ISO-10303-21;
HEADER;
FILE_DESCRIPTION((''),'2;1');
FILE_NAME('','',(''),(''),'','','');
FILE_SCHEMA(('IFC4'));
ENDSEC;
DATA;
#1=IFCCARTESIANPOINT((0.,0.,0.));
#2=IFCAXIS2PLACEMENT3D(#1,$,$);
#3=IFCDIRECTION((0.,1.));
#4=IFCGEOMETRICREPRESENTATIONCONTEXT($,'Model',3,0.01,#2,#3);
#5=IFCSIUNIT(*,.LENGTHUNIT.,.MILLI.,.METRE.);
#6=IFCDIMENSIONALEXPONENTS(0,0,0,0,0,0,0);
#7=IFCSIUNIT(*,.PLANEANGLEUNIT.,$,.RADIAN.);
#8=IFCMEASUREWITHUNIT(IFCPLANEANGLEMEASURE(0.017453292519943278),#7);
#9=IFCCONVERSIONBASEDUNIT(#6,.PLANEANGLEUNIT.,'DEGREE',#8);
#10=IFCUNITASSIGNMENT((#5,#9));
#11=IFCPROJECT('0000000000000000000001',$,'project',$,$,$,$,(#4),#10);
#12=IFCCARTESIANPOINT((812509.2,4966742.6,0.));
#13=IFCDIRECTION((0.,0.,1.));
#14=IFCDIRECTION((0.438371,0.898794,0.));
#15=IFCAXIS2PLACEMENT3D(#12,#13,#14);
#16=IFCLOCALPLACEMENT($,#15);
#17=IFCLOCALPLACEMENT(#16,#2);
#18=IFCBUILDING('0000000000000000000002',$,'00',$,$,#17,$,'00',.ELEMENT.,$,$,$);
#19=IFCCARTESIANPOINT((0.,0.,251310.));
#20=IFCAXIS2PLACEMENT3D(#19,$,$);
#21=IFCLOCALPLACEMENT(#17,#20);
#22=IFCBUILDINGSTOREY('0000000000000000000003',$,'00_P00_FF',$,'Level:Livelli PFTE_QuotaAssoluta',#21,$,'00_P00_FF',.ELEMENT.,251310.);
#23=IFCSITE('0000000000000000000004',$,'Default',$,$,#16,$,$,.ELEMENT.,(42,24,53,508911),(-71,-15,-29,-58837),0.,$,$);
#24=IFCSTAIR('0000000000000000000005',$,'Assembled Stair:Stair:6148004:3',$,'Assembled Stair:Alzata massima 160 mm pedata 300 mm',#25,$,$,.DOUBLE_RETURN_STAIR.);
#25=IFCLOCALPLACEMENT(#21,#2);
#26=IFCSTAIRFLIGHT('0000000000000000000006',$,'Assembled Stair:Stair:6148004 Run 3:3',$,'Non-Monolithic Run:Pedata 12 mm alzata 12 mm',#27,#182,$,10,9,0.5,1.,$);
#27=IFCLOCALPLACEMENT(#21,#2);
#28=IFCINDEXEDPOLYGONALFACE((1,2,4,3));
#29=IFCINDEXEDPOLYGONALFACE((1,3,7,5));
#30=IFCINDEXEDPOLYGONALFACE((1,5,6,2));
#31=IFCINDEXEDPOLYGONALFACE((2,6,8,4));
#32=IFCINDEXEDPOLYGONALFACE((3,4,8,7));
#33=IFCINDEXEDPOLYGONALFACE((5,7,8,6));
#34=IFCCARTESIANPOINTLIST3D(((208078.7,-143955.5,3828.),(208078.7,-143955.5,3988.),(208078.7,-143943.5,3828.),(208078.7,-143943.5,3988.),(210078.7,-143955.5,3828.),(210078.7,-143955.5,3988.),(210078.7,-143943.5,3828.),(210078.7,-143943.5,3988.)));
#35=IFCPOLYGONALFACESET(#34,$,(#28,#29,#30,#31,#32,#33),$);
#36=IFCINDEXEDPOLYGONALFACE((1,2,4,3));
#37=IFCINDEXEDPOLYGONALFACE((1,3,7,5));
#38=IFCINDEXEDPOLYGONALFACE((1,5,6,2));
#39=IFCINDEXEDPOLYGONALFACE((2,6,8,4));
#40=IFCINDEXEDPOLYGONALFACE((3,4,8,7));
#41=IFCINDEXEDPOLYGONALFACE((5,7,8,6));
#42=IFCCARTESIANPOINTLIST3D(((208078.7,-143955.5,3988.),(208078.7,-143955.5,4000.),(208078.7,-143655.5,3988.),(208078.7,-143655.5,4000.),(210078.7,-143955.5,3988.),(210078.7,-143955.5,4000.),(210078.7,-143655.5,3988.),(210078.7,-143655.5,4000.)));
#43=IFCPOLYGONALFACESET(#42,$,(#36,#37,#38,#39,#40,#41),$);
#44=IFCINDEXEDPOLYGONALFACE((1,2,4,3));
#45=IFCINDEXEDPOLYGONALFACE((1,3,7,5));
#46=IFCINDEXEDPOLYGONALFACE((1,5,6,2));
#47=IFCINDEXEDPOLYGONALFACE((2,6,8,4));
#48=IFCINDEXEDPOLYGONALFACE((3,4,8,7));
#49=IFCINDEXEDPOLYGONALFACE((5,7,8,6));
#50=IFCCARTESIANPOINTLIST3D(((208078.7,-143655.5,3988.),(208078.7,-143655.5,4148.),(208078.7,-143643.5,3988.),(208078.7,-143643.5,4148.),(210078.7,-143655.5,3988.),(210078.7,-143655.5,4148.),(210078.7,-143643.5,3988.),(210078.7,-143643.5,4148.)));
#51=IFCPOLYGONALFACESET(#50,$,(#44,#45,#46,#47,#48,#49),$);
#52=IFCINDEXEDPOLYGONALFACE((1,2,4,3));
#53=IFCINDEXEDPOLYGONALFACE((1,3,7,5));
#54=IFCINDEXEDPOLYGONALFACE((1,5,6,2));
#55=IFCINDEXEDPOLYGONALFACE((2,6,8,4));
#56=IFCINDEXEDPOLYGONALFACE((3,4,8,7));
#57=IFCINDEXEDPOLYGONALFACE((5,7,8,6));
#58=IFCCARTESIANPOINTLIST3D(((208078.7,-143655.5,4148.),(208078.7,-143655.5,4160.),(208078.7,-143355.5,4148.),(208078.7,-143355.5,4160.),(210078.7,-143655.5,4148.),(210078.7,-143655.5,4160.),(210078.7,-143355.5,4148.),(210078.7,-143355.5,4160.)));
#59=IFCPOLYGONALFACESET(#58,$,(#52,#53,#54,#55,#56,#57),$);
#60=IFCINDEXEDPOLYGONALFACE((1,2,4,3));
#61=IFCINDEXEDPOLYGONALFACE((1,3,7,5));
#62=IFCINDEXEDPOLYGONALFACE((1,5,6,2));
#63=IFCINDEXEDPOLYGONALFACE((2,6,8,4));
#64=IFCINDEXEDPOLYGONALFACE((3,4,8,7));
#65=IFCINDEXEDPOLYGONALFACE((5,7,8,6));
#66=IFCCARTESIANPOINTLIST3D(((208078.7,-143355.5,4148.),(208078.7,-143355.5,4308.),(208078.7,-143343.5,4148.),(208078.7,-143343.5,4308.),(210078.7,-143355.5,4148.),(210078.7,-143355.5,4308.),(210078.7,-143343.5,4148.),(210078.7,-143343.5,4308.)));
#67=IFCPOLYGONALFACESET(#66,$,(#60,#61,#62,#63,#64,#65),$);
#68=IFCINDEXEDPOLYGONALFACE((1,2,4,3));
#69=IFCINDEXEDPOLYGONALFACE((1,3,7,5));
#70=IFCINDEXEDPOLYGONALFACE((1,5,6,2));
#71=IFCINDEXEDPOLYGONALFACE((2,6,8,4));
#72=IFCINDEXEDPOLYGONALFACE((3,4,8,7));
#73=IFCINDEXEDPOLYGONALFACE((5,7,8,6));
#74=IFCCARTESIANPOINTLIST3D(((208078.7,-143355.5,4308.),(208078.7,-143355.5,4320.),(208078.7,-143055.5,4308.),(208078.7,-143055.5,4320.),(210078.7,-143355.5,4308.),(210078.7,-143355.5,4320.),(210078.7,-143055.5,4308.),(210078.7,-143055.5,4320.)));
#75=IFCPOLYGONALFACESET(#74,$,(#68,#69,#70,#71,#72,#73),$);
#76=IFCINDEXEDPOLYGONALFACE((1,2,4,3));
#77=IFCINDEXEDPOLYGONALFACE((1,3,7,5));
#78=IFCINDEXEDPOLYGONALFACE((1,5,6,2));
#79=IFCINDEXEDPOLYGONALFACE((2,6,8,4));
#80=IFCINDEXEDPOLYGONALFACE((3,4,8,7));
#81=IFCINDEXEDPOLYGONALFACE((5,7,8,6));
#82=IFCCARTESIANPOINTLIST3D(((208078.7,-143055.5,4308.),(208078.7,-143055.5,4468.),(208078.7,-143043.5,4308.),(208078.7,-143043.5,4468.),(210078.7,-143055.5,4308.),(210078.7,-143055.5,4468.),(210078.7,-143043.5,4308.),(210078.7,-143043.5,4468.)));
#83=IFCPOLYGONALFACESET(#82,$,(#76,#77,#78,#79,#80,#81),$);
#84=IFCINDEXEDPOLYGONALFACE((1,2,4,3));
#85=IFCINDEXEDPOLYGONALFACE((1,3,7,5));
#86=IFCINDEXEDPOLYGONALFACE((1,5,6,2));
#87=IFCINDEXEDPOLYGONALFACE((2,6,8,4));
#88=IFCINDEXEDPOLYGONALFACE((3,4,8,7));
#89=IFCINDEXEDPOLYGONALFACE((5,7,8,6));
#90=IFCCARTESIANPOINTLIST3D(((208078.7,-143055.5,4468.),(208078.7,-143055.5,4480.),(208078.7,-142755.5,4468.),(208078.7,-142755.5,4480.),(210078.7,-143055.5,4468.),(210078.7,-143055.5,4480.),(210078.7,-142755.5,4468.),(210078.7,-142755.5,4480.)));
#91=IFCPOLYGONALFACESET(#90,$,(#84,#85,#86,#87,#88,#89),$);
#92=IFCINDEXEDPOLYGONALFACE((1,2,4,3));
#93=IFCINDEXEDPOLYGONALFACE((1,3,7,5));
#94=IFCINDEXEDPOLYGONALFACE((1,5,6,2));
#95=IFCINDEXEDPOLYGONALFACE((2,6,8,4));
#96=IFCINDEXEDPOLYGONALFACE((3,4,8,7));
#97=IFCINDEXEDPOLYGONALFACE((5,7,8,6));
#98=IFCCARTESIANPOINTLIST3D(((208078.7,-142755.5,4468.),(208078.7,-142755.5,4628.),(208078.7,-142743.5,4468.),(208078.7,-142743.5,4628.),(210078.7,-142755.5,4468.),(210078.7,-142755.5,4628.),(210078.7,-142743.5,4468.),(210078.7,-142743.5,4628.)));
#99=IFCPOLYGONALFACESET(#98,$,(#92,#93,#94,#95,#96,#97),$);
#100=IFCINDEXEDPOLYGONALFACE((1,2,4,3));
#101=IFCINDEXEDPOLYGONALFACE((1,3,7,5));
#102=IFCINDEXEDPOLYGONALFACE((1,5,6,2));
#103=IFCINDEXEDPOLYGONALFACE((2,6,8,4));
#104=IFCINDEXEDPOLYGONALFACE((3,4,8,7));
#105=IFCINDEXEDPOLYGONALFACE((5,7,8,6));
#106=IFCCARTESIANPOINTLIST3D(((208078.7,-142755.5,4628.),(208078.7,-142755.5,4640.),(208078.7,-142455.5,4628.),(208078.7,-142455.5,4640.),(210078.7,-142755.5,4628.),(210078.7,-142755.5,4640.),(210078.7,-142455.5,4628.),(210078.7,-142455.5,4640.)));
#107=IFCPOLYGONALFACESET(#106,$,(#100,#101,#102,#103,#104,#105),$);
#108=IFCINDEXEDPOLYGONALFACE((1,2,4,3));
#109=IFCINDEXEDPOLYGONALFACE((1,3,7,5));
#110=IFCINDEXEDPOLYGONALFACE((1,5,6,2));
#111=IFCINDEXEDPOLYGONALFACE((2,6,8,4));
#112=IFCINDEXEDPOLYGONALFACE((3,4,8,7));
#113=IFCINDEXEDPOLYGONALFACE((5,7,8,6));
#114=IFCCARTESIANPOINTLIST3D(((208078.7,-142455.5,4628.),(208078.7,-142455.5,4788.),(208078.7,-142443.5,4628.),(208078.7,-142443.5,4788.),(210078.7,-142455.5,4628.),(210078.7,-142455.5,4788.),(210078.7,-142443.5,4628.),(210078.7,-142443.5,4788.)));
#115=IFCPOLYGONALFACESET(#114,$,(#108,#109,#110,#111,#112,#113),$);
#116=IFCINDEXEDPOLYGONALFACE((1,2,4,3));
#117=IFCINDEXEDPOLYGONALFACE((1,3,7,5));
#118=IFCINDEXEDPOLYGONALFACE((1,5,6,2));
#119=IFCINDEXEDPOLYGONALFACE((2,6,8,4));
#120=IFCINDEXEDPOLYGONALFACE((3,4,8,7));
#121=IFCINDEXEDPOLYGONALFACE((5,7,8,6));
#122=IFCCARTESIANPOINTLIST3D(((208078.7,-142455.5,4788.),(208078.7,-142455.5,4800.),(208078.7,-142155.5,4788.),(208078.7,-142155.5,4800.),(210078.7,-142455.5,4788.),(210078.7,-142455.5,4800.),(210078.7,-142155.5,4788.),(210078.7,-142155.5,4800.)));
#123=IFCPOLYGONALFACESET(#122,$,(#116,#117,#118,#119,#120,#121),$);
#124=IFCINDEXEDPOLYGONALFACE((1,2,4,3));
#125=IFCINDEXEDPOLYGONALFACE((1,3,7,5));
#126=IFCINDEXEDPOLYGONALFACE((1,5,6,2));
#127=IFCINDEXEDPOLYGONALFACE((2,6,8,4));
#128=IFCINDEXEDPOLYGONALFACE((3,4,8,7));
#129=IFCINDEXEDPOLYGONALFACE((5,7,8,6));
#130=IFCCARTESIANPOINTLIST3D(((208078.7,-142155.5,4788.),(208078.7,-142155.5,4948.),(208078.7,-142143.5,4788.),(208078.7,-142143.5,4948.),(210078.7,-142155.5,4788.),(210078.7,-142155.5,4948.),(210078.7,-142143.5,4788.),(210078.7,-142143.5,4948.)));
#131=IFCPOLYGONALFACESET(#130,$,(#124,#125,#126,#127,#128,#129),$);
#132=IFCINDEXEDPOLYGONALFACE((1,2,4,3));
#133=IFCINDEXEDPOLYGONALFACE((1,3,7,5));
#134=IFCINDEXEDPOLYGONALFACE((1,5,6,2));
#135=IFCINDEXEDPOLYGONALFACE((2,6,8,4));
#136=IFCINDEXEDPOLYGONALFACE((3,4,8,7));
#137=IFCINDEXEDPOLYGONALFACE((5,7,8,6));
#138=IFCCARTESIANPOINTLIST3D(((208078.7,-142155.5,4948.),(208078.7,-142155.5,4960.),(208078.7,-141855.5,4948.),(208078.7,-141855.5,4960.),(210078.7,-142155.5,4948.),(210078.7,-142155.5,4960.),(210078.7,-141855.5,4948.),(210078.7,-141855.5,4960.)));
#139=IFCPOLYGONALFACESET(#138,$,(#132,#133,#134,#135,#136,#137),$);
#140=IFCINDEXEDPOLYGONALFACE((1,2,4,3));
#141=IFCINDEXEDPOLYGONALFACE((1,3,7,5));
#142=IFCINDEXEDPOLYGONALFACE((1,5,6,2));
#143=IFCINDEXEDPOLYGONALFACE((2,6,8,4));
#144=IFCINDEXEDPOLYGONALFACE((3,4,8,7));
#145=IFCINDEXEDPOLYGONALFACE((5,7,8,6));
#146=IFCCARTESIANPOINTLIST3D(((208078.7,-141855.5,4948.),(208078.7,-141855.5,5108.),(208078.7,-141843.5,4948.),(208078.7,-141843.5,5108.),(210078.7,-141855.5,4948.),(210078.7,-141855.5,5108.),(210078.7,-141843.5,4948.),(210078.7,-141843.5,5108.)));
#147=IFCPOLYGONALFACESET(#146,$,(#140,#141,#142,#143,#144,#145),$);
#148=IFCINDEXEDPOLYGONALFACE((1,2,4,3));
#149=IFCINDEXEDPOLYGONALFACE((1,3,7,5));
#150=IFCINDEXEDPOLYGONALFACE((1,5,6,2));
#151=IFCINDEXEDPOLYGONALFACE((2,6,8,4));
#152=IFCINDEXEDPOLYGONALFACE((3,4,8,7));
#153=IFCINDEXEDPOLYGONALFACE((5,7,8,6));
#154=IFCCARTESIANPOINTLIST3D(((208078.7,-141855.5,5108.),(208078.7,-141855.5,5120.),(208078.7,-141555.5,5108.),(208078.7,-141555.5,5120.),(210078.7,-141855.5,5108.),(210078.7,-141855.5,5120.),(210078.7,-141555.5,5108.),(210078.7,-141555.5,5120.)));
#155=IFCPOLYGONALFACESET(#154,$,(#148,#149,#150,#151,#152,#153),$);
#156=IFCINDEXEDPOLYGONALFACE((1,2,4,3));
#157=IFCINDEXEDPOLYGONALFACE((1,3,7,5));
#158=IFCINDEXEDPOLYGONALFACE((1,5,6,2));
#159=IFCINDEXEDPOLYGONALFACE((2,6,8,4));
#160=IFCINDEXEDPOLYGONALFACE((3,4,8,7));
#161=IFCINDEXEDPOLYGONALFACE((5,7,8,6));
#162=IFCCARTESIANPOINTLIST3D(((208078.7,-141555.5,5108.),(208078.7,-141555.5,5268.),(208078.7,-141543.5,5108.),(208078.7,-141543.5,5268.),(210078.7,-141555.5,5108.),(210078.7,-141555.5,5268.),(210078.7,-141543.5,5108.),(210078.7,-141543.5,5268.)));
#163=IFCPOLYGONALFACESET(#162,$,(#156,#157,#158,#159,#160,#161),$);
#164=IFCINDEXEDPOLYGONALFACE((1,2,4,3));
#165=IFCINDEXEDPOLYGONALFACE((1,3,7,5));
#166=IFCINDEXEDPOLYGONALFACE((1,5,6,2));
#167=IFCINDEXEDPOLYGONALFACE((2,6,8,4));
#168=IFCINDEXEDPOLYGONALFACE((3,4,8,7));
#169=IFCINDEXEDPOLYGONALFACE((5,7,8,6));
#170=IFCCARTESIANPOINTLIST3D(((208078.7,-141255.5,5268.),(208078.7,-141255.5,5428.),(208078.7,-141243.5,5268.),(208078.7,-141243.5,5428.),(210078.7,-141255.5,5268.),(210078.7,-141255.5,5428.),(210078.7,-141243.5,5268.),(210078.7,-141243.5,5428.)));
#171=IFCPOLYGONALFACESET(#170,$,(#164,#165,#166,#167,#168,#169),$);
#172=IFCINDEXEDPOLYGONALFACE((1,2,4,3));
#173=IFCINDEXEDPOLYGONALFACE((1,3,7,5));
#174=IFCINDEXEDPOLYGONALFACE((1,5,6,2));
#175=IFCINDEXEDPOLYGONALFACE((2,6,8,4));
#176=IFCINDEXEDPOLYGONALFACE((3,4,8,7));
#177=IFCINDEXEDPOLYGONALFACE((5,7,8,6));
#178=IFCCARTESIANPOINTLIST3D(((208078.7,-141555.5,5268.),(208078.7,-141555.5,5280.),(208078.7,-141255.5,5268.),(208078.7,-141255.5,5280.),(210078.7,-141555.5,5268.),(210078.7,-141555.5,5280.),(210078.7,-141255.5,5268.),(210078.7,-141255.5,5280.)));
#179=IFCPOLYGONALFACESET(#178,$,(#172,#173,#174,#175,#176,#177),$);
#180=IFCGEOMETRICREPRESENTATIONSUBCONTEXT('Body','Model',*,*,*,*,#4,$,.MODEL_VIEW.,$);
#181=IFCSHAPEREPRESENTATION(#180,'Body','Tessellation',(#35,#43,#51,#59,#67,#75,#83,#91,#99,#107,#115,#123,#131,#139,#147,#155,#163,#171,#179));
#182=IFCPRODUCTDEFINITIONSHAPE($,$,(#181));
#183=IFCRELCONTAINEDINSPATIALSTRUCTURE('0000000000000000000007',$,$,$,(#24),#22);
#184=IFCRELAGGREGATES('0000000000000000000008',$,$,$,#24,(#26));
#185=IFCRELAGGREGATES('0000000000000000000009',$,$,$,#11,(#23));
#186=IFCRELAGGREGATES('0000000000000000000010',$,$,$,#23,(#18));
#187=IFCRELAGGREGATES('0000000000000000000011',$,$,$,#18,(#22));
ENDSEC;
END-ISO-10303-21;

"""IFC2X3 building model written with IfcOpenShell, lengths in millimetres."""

from ifc_helpers import new_model, entity, si_unit, converted_unit, direction, frame, origin, origin_2d_with_axis, place, context, subcontext, project, spatial, rectangle, extrude, element, aggregate, save


model = new_model("IFC2X3")

# Units and contexts
model_context = context("Model", 3, precision=0.01, world=origin(), true_north=direction((0.0, 1.0)))
body_context = subcontext(model_context, "Body", "Model", "MODEL_VIEW")
ifc_project = project(units=[si_unit("LENGTHUNIT", "METRE", prefix="MILLI"), converted_unit("PLANEANGLEUNIT", "DEGREE", entity("IfcPlaneAngleMeasure", 0.017453292519943278), si_unit("PLANEANGLEUNIT", "RADIAN"), dimensions=[0, 0, 0, 0, 0, 0, 0])], contexts=[model_context])

# Site, building, storey
site_placement = place(None, frame((812509.2, 4966742.6, 0.0), z_axis=(0.0, 0.0, 1.0), x_axis=(0.438371, 0.898794, 0.0)))
site = spatial("IfcSite", under=ifc_project, at=site_placement, Name="Default", CompositionType="ELEMENT", RefLatitude=(42, 24, 53, 508911), RefLongitude=(-71, -15, -29, -58837), RefElevation=0.0)
building_placement = place(site_placement, origin())
building = spatial("IfcBuilding", under=site, at=building_placement, Name="00", LongName="00", CompositionType="ELEMENT")
storey_placement = place(building_placement, frame((0.0, 0.0, 251310.0)))
storey = spatial("IfcBuildingStorey", under=building, at=storey_placement, Name="00_P00_FF", ObjectType="Level:Livelli PFTE_QuotaAssoluta", LongName="00_P00_FF", CompositionType="ELEMENT", Elevation=251310.0)

# Stair
stair_1_placement = place(storey_placement, origin())
stair_1 = element("IfcStair", 1, at=stair_1_placement, inside=storey, Name="Assembled Stair:Stair:6148004:3", ObjectType="Assembled Stair:Alzata massima 160 mm pedata 300 mm", ShapeType="DOUBLE_RETURN_STAIR")

# Stair flight
stair_flight_1_placement = place(stair_1_placement, origin())
stair_flight_1 = element("IfcStairFlight", 2, at=stair_flight_1_placement, Name="Assembled Stair:Stair:6148004 Run 3:3", ObjectType="Non-Monolithic Run:Pedata 12 mm alzata 12 mm", NumberOfRiser=10, NumberOfTreads=9, RiserHeight=0.5, TreadLength=1.0, context=body_context, shape_type="SweptSolid", body=[
    extrude(rectangle(XDim=2000.0, YDim=12.0, at=origin_2d_with_axis()), frame((209078.7, -143949.5, 3828.0), z_axis=(0.0, 0.0, 1.0), x_axis=(-1.0, 0.0, 0.0)), (0.0, 0.0, 1.0), 160.0),
    extrude(rectangle(XDim=300.0, YDim=2000.0, at=origin_2d_with_axis()), frame((209078.7, -143805.5, 3988.0), z_axis=(0.0, 0.0, 1.0), x_axis=(0.0, -1.0, 0.0)), (0.0, 0.0, 1.0), 12.0),
    extrude(rectangle(XDim=2000.0, YDim=12.0, at=origin_2d_with_axis()), frame((209078.7, -143649.5, 3988.0), z_axis=(0.0, 0.0, 1.0), x_axis=(-1.0, 0.0, 0.0)), (0.0, 0.0, 1.0), 160.0),
    extrude(rectangle(XDim=300.0, YDim=2000.0, at=origin_2d_with_axis()), frame((209078.7, -143505.5, 4148.0), z_axis=(0.0, 0.0, 1.0), x_axis=(0.0, -1.0, 0.0)), (0.0, 0.0, 1.0), 12.0),
    extrude(rectangle(XDim=2000.0, YDim=12.0, at=origin_2d_with_axis()), frame((209078.7, -143349.5, 4148.0), z_axis=(0.0, 0.0, 1.0), x_axis=(-1.0, 0.0, 0.0)), (0.0, 0.0, 1.0), 160.0),
    extrude(rectangle(XDim=300.0, YDim=2000.0, at=origin_2d_with_axis()), frame((209078.7, -143205.5, 4308.0), z_axis=(0.0, 0.0, 1.0), x_axis=(0.0, -1.0, 0.0)), (0.0, 0.0, 1.0), 12.0),
    extrude(rectangle(XDim=2000.0, YDim=12.0, at=origin_2d_with_axis()), frame((209078.7, -143049.5, 4308.0), z_axis=(0.0, 0.0, 1.0), x_axis=(-1.0, 0.0, 0.0)), (0.0, 0.0, 1.0), 160.0),
    extrude(rectangle(XDim=300.0, YDim=2000.0, at=origin_2d_with_axis()), frame((209078.7, -142905.5, 4468.0), z_axis=(0.0, 0.0, 1.0), x_axis=(0.0, -1.0, 0.0)), (0.0, 0.0, 1.0), 12.0),
    extrude(rectangle(XDim=2000.0, YDim=12.0, at=origin_2d_with_axis()), frame((209078.7, -142749.5, 4468.0), z_axis=(0.0, 0.0, 1.0), x_axis=(-1.0, 0.0, 0.0)), (0.0, 0.0, 1.0), 160.0),
    extrude(rectangle(XDim=300.0, YDim=2000.0, at=origin_2d_with_axis()), frame((209078.7, -142605.5, 4628.0), z_axis=(0.0, 0.0, 1.0), x_axis=(0.0, -1.0, 0.0)), (0.0, 0.0, 1.0), 12.0),
    extrude(rectangle(XDim=2000.0, YDim=12.0, at=origin_2d_with_axis()), frame((209078.7, -142449.5, 4628.0), z_axis=(0.0, 0.0, 1.0), x_axis=(-1.0, 0.0, 0.0)), (0.0, 0.0, 1.0), 160.0),
    extrude(rectangle(XDim=300.0, YDim=2000.0, at=origin_2d_with_axis()), frame((209078.7, -142305.5, 4788.0), z_axis=(0.0, 0.0, 1.0), x_axis=(0.0, -1.0, 0.0)), (0.0, 0.0, 1.0), 12.0),
    extrude(rectangle(XDim=2000.0, YDim=12.0, at=origin_2d_with_axis()), frame((209078.7, -142149.5, 4788.0), z_axis=(0.0, 0.0, 1.0), x_axis=(-1.0, 0.0, 0.0)), (0.0, 0.0, 1.0), 160.0),
    extrude(rectangle(XDim=300.0, YDim=2000.0, at=origin_2d_with_axis()), frame((209078.7, -142005.5, 4948.0), z_axis=(0.0, 0.0, 1.0), x_axis=(0.0, -1.0, 0.0)), (0.0, 0.0, 1.0), 12.0),
    extrude(rectangle(XDim=2000.0, YDim=12.0, at=origin_2d_with_axis()), frame((209078.7, -141849.5, 4948.0), z_axis=(0.0, 0.0, 1.0), x_axis=(-1.0, 0.0, 0.0)), (0.0, 0.0, 1.0), 160.0),
    extrude(rectangle(XDim=300.0, YDim=2000.0, at=origin_2d_with_axis()), frame((209078.7, -141705.5, 5108.0), z_axis=(0.0, 0.0, 1.0), x_axis=(0.0, -1.0, 0.0)), (0.0, 0.0, 1.0), 12.0),
    extrude(rectangle(XDim=2000.0, YDim=12.0, at=origin_2d_with_axis()), frame((209078.7, -141549.5, 5108.0), z_axis=(0.0, 0.0, 1.0), x_axis=(-1.0, 0.0, 0.0)), (0.0, 0.0, 1.0), 160.0),
    extrude(rectangle(XDim=2000.0, YDim=12.0, at=origin_2d_with_axis()), frame((209078.7, -141249.5, 5268.0), z_axis=(0.0, 0.0, 1.0), x_axis=(-1.0, 0.0, 0.0)), (0.0, 0.0, 1.0), 160.0),
    extrude(rectangle(XDim=300.0, YDim=2000.0, at=origin_2d_with_axis()), frame((209078.7, -141405.5, 5268.0), z_axis=(0.0, 0.0, 1.0), x_axis=(0.0, -1.0, 0.0)), (0.0, 0.0, 1.0), 12.0),
])
aggregate(stair_1, [stair_flight_1])

save(model, "model.ifc")
